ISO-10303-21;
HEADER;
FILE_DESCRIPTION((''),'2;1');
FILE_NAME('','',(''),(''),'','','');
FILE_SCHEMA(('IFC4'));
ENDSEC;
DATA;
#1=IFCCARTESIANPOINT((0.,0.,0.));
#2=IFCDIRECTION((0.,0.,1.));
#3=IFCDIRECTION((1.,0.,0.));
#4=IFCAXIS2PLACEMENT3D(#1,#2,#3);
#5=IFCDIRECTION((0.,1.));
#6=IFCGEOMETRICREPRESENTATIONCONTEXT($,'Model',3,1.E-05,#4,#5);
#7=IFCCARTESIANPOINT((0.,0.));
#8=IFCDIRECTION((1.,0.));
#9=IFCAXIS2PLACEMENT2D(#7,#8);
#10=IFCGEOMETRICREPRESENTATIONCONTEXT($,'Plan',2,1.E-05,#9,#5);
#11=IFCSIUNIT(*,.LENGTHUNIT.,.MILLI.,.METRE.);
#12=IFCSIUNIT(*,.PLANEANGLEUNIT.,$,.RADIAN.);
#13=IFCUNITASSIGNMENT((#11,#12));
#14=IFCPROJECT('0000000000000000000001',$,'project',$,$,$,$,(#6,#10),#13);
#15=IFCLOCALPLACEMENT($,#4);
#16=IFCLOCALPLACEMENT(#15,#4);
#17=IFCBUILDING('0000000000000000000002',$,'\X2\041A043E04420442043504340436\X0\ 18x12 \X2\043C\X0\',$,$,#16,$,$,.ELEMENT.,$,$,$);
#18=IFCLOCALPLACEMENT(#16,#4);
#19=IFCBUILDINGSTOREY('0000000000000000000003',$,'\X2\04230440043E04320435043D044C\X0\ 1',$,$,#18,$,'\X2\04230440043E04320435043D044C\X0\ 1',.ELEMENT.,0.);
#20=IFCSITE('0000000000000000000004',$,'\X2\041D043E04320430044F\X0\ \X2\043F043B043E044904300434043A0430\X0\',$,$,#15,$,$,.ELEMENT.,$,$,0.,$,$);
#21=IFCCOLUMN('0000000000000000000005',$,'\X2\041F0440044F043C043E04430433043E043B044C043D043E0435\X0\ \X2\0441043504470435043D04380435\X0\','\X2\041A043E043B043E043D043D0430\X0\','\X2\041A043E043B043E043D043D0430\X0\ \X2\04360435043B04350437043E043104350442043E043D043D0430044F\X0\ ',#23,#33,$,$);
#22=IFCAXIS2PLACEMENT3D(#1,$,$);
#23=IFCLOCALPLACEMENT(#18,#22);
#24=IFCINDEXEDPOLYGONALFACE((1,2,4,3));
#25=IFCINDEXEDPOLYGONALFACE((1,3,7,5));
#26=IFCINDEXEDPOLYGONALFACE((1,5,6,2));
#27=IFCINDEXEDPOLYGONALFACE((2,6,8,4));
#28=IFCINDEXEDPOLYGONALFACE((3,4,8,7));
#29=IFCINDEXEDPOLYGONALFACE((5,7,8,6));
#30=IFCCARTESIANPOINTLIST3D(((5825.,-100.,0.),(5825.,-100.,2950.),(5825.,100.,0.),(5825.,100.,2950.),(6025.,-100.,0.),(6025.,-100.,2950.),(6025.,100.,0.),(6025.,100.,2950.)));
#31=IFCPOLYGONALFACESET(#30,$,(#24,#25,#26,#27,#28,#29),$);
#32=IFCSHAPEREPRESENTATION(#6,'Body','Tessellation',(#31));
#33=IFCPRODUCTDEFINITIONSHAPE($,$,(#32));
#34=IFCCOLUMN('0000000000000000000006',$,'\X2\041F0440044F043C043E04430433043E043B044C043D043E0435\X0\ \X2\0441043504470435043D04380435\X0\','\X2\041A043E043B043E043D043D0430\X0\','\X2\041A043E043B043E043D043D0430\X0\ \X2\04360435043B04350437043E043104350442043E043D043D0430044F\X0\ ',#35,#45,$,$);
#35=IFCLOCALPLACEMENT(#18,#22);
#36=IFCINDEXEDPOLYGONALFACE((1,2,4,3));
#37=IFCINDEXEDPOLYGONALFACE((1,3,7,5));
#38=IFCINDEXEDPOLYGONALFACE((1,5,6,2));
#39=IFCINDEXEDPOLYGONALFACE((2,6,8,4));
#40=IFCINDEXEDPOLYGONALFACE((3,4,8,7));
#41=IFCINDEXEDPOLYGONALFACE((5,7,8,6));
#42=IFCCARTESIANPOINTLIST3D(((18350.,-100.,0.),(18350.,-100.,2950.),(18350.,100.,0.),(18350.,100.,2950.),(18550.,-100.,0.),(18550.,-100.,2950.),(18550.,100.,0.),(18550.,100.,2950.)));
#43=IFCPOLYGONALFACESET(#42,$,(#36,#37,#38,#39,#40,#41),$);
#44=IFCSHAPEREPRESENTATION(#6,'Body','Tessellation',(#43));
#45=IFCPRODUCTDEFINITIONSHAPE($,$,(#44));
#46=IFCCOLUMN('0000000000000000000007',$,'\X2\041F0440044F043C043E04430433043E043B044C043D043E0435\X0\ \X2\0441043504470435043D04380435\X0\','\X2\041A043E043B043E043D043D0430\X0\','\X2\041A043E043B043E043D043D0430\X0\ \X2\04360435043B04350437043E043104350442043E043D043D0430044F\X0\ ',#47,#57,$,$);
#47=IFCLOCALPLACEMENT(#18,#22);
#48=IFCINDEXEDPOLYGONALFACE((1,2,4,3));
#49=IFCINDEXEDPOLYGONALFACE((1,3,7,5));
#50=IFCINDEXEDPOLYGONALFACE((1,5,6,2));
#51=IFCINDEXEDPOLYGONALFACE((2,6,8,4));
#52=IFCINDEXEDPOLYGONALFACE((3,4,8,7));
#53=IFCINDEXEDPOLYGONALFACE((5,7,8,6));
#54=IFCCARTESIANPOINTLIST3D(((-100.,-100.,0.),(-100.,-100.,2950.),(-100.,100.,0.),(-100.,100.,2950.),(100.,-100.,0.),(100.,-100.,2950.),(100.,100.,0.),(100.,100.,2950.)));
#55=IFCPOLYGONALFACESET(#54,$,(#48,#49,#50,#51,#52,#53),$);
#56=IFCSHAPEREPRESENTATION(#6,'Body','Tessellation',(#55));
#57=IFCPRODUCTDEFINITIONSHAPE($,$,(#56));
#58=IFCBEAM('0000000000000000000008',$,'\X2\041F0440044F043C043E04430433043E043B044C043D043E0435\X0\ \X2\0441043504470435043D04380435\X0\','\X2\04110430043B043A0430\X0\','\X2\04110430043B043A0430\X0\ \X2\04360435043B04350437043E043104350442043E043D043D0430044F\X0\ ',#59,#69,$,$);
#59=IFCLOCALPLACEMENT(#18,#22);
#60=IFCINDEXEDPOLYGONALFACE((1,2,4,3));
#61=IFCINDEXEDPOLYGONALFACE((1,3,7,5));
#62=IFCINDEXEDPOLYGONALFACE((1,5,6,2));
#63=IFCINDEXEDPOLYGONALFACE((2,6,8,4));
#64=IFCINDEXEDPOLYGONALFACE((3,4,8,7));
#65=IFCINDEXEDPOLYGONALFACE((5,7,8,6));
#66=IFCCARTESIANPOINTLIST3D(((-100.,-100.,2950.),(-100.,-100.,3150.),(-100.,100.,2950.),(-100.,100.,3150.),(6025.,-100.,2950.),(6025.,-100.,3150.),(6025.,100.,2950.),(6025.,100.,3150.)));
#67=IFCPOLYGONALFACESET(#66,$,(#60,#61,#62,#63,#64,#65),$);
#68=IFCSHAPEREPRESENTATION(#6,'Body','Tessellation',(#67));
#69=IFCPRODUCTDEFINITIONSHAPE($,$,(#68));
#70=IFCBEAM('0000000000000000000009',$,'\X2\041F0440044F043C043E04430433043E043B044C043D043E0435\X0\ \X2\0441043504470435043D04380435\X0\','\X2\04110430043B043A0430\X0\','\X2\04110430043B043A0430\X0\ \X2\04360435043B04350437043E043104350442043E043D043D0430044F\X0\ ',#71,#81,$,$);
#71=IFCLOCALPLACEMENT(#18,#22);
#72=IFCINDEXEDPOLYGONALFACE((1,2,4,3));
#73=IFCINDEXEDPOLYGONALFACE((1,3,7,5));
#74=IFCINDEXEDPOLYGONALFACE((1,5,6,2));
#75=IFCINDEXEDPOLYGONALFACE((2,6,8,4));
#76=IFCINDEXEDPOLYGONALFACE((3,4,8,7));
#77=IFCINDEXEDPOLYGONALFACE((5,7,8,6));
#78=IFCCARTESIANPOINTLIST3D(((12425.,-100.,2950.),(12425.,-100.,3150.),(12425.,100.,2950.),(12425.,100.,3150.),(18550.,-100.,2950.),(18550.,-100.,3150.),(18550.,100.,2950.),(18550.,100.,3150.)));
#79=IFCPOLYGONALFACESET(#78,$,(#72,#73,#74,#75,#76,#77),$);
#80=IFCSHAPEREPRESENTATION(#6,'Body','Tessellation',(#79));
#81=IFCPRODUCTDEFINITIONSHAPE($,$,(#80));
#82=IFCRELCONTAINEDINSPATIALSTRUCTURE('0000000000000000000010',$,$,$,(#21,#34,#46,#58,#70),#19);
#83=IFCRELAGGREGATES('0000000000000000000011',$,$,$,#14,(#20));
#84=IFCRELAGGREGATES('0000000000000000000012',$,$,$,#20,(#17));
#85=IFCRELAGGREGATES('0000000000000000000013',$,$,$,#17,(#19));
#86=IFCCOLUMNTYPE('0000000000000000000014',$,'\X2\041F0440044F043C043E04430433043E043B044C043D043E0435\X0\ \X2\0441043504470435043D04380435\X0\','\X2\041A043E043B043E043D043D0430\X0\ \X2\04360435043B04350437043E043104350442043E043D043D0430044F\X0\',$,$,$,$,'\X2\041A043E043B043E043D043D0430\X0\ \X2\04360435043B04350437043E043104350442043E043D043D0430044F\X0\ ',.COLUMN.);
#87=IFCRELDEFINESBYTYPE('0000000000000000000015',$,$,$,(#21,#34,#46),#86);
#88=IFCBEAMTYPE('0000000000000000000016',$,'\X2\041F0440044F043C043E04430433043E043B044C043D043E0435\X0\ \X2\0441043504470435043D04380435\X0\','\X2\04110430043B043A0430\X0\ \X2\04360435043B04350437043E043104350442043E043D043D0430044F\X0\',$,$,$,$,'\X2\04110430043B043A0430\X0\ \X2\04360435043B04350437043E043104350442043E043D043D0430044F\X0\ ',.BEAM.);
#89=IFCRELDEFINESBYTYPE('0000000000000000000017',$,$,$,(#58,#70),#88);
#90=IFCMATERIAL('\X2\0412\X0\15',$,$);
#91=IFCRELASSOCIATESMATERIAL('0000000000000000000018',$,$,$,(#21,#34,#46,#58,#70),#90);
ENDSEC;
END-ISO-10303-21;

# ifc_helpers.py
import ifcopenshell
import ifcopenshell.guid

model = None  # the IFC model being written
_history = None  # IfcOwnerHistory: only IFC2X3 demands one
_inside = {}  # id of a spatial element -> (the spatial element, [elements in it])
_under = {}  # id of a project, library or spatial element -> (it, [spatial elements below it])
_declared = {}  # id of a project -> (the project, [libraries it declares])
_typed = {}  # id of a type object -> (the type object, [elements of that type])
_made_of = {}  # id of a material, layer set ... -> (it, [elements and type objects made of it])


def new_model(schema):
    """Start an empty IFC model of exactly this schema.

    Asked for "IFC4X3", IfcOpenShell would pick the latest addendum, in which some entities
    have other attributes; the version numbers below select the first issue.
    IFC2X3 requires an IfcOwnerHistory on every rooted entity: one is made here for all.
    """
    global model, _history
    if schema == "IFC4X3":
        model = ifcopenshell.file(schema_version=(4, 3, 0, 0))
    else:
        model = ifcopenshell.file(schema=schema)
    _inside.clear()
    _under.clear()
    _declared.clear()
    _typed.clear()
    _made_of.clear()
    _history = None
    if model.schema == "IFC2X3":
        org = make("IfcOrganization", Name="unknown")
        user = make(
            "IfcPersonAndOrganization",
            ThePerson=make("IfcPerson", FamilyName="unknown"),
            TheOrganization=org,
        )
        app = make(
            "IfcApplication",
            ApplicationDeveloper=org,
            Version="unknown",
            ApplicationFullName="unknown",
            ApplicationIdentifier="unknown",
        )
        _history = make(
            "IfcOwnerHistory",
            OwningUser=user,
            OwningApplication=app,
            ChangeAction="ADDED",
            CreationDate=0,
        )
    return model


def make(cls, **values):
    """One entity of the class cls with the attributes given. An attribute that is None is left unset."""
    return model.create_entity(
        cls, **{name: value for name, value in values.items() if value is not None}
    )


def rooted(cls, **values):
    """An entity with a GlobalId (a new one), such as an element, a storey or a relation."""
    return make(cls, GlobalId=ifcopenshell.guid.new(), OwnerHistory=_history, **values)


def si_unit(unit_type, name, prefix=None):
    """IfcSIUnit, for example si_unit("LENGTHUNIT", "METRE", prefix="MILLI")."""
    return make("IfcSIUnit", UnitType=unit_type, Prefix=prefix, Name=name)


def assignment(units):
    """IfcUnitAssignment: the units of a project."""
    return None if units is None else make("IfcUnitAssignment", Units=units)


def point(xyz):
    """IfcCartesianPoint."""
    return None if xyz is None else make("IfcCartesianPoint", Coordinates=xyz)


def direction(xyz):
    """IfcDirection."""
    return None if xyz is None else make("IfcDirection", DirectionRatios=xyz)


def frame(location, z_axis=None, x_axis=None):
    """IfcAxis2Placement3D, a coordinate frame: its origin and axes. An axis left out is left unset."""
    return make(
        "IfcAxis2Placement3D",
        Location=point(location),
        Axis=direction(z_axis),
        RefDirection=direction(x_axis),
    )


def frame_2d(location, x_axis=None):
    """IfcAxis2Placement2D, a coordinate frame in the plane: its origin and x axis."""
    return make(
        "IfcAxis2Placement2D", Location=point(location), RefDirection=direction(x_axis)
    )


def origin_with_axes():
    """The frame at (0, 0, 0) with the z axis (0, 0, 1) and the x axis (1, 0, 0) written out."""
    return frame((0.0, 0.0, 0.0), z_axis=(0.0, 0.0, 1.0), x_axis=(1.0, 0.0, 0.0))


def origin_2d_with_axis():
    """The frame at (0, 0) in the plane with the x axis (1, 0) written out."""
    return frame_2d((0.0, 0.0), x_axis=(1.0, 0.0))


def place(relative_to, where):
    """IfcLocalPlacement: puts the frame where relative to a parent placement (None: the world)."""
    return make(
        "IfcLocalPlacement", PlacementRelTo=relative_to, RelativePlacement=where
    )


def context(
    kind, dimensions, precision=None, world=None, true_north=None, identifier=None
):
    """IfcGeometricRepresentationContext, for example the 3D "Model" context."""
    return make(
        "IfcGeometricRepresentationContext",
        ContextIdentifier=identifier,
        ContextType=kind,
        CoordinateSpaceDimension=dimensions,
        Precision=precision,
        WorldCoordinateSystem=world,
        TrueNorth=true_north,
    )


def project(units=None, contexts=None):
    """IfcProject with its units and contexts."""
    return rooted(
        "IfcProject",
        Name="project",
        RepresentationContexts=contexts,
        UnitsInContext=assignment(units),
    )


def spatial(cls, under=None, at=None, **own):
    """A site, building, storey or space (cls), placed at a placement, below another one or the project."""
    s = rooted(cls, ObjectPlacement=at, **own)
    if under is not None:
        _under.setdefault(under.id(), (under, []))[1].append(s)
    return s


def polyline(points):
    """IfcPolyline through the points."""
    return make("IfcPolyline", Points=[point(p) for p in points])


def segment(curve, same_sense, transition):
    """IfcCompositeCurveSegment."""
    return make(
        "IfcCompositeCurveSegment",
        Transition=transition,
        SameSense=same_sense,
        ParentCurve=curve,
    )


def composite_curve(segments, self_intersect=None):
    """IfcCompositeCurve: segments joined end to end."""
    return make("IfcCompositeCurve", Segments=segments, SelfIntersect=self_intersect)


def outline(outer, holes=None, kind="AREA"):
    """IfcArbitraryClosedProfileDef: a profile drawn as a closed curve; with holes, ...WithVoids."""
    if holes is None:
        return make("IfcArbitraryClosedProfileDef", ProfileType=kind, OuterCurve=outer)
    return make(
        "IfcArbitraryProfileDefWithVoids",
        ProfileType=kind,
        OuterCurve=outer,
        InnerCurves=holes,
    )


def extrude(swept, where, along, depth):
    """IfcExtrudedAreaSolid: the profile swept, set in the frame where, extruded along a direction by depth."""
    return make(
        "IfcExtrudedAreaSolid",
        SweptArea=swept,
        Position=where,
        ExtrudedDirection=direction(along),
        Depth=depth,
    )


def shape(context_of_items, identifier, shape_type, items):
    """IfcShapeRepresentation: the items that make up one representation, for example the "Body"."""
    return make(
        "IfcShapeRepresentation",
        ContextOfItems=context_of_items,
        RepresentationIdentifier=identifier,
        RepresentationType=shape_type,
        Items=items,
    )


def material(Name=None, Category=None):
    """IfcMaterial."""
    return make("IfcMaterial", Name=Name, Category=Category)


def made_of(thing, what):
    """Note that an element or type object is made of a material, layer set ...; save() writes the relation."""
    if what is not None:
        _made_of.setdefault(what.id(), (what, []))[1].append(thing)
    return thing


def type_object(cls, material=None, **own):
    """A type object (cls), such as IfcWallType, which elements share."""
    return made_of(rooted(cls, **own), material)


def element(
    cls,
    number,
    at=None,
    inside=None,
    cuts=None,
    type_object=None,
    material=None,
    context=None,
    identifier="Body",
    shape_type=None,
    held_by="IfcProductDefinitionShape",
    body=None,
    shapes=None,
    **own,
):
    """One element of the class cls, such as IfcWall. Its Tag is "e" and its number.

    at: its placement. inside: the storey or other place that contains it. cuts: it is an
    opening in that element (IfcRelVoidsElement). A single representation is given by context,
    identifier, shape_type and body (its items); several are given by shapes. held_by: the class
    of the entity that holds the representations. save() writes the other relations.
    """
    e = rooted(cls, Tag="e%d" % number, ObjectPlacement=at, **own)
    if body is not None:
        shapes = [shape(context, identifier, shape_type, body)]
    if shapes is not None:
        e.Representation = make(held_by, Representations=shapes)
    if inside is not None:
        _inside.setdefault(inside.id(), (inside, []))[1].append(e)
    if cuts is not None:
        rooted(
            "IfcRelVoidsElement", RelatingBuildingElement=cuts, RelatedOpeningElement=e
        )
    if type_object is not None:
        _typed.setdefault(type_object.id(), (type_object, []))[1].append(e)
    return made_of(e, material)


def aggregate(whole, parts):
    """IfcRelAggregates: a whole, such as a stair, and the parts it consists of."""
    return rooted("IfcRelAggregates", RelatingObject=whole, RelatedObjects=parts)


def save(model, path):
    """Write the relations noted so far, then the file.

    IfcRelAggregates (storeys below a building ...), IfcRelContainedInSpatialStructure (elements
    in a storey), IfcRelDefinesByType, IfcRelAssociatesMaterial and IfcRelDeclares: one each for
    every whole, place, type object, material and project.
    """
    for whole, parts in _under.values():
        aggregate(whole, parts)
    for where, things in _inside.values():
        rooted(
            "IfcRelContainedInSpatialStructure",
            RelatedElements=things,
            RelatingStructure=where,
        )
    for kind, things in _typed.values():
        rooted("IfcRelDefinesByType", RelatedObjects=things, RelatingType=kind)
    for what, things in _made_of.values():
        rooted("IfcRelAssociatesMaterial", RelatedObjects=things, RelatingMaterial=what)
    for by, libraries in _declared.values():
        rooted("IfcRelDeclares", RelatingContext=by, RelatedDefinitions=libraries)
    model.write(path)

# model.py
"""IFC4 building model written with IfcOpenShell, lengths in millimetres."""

from ifc_helpers import new_model, si_unit, direction, frame, origin_with_axes, origin_2d_with_axis, place, context, project, spatial, polyline, segment, composite_curve, outline, extrude, material, type_object, element, save


model = new_model("IFC4")

# Units and contexts
model_context = context("Model", 3, precision=1e-05, world=origin_with_axes(), true_north=direction((0.0, 1.0)))
plan_context = context("Plan", 2, precision=1e-05, world=origin_2d_with_axis(), true_north=direction((0.0, 1.0)))
ifc_project = project(units=[si_unit("LENGTHUNIT", "METRE", prefix="MILLI"), si_unit("PLANEANGLEUNIT", "RADIAN")], contexts=[model_context, plan_context])

# Site, building, storey
site_placement = place(None, origin_with_axes())
site = spatial("IfcSite", under=ifc_project, at=site_placement, Name="Новая площадка", CompositionType="ELEMENT", RefElevation=0.0)
building_placement = place(site_placement, origin_with_axes())
building = spatial("IfcBuilding", under=site, at=building_placement, Name="Коттедж 18x12 м", CompositionType="ELEMENT")
storey_placement = place(building_placement, origin_with_axes())
storey = spatial("IfcBuildingStorey", under=building, at=storey_placement, Name="Уровень 1", LongName="Уровень 1", CompositionType="ELEMENT", Elevation=0.0)

# Columns
ifc_material = material(Name="В15")
column_type = type_object("IfcColumnType", Name="Прямоугольное сечение", Description="Колонна железобетонная", ElementType="Колонна железобетонная ", PredefinedType="COLUMN")
for number, where, z_axis, x_axis, name in (
    (1, (5925.0, 0.0, 0.0), (0.0, 0.0, 1.0), (1.0, 0.0, 0.0), "Прямоугольное сечение"),
    (2, (18450.0, 0.0, 0.0), (0.0, 0.0, 1.0), (1.0, 0.0, 0.0), "Прямоугольное сечение"),
    (3, (0.0, 0.0, 0.0), (0.0, 0.0, 1.0), (1.0, 0.0, 0.0), "Прямоугольное сечение"),
):
    element("IfcColumn", number, at=place(None, frame(where, z_axis=z_axis, x_axis=x_axis)), inside=storey, type_object=column_type, material=ifc_material, Name=name, Description="Колонна", ObjectType="Колонна железобетонная ", context=model_context, shape_type="SweptSolid", body=[
        extrude(outline(composite_curve([segment(polyline([(100.0, -100.0), (100.0, 100.0)]), True, "CONTINUOUS"), segment(polyline([(100.0, 100.0), (-100.0, 100.0)]), True, "CONTINUOUS"), segment(polyline([(-100.0, 100.0), (-100.0, -100.0)]), True, "CONTINUOUS"), segment(polyline([(-100.0, -100.0), (100.0, -100.0)]), True, "DISCONTINUOUS")], self_intersect=False)), origin_with_axes(), (0.0, 0.0, 1.0), 2950.0),
    ])

# Beams
beam_type = type_object("IfcBeamType", Name="Прямоугольное сечение", Description="Балка железобетонная", ElementType="Балка железобетонная ", PredefinedType="BEAM")
for number, where, z_axis, x_axis, name in (
    (4, (-100.0, 0.0, 3050.0), (1.0, 0.0, 0.0), (0.0, 1.0, 0.0), "Прямоугольное сечение"),
    (5, (18550.0, 0.0, 3050.0), (-1.0, 0.0, 0.0), (0.0, -1.0, 0.0), "Прямоугольное сечение"),
):
    element("IfcBeam", number, at=place(None, frame(where, z_axis=z_axis, x_axis=x_axis)), inside=storey, type_object=beam_type, material=ifc_material, Name=name, Description="Балка", ObjectType="Балка железобетонная ", context=model_context, shape_type="SweptSolid", body=[
        extrude(outline(composite_curve([segment(polyline([(100.0, -100.0), (100.0, 100.0)]), True, "CONTINUOUS"), segment(polyline([(100.0, 100.0), (-100.0, 100.0)]), True, "CONTINUOUS"), segment(polyline([(-100.0, 100.0), (-100.0, -100.0)]), True, "CONTINUOUS"), segment(polyline([(-100.0, -100.0), (100.0, -100.0)]), True, "DISCONTINUOUS")], self_intersect=False)), origin_with_axes(), (0.0, 0.0, 1.0), 6125.0),
    ])

save(model, "model.ifc")
